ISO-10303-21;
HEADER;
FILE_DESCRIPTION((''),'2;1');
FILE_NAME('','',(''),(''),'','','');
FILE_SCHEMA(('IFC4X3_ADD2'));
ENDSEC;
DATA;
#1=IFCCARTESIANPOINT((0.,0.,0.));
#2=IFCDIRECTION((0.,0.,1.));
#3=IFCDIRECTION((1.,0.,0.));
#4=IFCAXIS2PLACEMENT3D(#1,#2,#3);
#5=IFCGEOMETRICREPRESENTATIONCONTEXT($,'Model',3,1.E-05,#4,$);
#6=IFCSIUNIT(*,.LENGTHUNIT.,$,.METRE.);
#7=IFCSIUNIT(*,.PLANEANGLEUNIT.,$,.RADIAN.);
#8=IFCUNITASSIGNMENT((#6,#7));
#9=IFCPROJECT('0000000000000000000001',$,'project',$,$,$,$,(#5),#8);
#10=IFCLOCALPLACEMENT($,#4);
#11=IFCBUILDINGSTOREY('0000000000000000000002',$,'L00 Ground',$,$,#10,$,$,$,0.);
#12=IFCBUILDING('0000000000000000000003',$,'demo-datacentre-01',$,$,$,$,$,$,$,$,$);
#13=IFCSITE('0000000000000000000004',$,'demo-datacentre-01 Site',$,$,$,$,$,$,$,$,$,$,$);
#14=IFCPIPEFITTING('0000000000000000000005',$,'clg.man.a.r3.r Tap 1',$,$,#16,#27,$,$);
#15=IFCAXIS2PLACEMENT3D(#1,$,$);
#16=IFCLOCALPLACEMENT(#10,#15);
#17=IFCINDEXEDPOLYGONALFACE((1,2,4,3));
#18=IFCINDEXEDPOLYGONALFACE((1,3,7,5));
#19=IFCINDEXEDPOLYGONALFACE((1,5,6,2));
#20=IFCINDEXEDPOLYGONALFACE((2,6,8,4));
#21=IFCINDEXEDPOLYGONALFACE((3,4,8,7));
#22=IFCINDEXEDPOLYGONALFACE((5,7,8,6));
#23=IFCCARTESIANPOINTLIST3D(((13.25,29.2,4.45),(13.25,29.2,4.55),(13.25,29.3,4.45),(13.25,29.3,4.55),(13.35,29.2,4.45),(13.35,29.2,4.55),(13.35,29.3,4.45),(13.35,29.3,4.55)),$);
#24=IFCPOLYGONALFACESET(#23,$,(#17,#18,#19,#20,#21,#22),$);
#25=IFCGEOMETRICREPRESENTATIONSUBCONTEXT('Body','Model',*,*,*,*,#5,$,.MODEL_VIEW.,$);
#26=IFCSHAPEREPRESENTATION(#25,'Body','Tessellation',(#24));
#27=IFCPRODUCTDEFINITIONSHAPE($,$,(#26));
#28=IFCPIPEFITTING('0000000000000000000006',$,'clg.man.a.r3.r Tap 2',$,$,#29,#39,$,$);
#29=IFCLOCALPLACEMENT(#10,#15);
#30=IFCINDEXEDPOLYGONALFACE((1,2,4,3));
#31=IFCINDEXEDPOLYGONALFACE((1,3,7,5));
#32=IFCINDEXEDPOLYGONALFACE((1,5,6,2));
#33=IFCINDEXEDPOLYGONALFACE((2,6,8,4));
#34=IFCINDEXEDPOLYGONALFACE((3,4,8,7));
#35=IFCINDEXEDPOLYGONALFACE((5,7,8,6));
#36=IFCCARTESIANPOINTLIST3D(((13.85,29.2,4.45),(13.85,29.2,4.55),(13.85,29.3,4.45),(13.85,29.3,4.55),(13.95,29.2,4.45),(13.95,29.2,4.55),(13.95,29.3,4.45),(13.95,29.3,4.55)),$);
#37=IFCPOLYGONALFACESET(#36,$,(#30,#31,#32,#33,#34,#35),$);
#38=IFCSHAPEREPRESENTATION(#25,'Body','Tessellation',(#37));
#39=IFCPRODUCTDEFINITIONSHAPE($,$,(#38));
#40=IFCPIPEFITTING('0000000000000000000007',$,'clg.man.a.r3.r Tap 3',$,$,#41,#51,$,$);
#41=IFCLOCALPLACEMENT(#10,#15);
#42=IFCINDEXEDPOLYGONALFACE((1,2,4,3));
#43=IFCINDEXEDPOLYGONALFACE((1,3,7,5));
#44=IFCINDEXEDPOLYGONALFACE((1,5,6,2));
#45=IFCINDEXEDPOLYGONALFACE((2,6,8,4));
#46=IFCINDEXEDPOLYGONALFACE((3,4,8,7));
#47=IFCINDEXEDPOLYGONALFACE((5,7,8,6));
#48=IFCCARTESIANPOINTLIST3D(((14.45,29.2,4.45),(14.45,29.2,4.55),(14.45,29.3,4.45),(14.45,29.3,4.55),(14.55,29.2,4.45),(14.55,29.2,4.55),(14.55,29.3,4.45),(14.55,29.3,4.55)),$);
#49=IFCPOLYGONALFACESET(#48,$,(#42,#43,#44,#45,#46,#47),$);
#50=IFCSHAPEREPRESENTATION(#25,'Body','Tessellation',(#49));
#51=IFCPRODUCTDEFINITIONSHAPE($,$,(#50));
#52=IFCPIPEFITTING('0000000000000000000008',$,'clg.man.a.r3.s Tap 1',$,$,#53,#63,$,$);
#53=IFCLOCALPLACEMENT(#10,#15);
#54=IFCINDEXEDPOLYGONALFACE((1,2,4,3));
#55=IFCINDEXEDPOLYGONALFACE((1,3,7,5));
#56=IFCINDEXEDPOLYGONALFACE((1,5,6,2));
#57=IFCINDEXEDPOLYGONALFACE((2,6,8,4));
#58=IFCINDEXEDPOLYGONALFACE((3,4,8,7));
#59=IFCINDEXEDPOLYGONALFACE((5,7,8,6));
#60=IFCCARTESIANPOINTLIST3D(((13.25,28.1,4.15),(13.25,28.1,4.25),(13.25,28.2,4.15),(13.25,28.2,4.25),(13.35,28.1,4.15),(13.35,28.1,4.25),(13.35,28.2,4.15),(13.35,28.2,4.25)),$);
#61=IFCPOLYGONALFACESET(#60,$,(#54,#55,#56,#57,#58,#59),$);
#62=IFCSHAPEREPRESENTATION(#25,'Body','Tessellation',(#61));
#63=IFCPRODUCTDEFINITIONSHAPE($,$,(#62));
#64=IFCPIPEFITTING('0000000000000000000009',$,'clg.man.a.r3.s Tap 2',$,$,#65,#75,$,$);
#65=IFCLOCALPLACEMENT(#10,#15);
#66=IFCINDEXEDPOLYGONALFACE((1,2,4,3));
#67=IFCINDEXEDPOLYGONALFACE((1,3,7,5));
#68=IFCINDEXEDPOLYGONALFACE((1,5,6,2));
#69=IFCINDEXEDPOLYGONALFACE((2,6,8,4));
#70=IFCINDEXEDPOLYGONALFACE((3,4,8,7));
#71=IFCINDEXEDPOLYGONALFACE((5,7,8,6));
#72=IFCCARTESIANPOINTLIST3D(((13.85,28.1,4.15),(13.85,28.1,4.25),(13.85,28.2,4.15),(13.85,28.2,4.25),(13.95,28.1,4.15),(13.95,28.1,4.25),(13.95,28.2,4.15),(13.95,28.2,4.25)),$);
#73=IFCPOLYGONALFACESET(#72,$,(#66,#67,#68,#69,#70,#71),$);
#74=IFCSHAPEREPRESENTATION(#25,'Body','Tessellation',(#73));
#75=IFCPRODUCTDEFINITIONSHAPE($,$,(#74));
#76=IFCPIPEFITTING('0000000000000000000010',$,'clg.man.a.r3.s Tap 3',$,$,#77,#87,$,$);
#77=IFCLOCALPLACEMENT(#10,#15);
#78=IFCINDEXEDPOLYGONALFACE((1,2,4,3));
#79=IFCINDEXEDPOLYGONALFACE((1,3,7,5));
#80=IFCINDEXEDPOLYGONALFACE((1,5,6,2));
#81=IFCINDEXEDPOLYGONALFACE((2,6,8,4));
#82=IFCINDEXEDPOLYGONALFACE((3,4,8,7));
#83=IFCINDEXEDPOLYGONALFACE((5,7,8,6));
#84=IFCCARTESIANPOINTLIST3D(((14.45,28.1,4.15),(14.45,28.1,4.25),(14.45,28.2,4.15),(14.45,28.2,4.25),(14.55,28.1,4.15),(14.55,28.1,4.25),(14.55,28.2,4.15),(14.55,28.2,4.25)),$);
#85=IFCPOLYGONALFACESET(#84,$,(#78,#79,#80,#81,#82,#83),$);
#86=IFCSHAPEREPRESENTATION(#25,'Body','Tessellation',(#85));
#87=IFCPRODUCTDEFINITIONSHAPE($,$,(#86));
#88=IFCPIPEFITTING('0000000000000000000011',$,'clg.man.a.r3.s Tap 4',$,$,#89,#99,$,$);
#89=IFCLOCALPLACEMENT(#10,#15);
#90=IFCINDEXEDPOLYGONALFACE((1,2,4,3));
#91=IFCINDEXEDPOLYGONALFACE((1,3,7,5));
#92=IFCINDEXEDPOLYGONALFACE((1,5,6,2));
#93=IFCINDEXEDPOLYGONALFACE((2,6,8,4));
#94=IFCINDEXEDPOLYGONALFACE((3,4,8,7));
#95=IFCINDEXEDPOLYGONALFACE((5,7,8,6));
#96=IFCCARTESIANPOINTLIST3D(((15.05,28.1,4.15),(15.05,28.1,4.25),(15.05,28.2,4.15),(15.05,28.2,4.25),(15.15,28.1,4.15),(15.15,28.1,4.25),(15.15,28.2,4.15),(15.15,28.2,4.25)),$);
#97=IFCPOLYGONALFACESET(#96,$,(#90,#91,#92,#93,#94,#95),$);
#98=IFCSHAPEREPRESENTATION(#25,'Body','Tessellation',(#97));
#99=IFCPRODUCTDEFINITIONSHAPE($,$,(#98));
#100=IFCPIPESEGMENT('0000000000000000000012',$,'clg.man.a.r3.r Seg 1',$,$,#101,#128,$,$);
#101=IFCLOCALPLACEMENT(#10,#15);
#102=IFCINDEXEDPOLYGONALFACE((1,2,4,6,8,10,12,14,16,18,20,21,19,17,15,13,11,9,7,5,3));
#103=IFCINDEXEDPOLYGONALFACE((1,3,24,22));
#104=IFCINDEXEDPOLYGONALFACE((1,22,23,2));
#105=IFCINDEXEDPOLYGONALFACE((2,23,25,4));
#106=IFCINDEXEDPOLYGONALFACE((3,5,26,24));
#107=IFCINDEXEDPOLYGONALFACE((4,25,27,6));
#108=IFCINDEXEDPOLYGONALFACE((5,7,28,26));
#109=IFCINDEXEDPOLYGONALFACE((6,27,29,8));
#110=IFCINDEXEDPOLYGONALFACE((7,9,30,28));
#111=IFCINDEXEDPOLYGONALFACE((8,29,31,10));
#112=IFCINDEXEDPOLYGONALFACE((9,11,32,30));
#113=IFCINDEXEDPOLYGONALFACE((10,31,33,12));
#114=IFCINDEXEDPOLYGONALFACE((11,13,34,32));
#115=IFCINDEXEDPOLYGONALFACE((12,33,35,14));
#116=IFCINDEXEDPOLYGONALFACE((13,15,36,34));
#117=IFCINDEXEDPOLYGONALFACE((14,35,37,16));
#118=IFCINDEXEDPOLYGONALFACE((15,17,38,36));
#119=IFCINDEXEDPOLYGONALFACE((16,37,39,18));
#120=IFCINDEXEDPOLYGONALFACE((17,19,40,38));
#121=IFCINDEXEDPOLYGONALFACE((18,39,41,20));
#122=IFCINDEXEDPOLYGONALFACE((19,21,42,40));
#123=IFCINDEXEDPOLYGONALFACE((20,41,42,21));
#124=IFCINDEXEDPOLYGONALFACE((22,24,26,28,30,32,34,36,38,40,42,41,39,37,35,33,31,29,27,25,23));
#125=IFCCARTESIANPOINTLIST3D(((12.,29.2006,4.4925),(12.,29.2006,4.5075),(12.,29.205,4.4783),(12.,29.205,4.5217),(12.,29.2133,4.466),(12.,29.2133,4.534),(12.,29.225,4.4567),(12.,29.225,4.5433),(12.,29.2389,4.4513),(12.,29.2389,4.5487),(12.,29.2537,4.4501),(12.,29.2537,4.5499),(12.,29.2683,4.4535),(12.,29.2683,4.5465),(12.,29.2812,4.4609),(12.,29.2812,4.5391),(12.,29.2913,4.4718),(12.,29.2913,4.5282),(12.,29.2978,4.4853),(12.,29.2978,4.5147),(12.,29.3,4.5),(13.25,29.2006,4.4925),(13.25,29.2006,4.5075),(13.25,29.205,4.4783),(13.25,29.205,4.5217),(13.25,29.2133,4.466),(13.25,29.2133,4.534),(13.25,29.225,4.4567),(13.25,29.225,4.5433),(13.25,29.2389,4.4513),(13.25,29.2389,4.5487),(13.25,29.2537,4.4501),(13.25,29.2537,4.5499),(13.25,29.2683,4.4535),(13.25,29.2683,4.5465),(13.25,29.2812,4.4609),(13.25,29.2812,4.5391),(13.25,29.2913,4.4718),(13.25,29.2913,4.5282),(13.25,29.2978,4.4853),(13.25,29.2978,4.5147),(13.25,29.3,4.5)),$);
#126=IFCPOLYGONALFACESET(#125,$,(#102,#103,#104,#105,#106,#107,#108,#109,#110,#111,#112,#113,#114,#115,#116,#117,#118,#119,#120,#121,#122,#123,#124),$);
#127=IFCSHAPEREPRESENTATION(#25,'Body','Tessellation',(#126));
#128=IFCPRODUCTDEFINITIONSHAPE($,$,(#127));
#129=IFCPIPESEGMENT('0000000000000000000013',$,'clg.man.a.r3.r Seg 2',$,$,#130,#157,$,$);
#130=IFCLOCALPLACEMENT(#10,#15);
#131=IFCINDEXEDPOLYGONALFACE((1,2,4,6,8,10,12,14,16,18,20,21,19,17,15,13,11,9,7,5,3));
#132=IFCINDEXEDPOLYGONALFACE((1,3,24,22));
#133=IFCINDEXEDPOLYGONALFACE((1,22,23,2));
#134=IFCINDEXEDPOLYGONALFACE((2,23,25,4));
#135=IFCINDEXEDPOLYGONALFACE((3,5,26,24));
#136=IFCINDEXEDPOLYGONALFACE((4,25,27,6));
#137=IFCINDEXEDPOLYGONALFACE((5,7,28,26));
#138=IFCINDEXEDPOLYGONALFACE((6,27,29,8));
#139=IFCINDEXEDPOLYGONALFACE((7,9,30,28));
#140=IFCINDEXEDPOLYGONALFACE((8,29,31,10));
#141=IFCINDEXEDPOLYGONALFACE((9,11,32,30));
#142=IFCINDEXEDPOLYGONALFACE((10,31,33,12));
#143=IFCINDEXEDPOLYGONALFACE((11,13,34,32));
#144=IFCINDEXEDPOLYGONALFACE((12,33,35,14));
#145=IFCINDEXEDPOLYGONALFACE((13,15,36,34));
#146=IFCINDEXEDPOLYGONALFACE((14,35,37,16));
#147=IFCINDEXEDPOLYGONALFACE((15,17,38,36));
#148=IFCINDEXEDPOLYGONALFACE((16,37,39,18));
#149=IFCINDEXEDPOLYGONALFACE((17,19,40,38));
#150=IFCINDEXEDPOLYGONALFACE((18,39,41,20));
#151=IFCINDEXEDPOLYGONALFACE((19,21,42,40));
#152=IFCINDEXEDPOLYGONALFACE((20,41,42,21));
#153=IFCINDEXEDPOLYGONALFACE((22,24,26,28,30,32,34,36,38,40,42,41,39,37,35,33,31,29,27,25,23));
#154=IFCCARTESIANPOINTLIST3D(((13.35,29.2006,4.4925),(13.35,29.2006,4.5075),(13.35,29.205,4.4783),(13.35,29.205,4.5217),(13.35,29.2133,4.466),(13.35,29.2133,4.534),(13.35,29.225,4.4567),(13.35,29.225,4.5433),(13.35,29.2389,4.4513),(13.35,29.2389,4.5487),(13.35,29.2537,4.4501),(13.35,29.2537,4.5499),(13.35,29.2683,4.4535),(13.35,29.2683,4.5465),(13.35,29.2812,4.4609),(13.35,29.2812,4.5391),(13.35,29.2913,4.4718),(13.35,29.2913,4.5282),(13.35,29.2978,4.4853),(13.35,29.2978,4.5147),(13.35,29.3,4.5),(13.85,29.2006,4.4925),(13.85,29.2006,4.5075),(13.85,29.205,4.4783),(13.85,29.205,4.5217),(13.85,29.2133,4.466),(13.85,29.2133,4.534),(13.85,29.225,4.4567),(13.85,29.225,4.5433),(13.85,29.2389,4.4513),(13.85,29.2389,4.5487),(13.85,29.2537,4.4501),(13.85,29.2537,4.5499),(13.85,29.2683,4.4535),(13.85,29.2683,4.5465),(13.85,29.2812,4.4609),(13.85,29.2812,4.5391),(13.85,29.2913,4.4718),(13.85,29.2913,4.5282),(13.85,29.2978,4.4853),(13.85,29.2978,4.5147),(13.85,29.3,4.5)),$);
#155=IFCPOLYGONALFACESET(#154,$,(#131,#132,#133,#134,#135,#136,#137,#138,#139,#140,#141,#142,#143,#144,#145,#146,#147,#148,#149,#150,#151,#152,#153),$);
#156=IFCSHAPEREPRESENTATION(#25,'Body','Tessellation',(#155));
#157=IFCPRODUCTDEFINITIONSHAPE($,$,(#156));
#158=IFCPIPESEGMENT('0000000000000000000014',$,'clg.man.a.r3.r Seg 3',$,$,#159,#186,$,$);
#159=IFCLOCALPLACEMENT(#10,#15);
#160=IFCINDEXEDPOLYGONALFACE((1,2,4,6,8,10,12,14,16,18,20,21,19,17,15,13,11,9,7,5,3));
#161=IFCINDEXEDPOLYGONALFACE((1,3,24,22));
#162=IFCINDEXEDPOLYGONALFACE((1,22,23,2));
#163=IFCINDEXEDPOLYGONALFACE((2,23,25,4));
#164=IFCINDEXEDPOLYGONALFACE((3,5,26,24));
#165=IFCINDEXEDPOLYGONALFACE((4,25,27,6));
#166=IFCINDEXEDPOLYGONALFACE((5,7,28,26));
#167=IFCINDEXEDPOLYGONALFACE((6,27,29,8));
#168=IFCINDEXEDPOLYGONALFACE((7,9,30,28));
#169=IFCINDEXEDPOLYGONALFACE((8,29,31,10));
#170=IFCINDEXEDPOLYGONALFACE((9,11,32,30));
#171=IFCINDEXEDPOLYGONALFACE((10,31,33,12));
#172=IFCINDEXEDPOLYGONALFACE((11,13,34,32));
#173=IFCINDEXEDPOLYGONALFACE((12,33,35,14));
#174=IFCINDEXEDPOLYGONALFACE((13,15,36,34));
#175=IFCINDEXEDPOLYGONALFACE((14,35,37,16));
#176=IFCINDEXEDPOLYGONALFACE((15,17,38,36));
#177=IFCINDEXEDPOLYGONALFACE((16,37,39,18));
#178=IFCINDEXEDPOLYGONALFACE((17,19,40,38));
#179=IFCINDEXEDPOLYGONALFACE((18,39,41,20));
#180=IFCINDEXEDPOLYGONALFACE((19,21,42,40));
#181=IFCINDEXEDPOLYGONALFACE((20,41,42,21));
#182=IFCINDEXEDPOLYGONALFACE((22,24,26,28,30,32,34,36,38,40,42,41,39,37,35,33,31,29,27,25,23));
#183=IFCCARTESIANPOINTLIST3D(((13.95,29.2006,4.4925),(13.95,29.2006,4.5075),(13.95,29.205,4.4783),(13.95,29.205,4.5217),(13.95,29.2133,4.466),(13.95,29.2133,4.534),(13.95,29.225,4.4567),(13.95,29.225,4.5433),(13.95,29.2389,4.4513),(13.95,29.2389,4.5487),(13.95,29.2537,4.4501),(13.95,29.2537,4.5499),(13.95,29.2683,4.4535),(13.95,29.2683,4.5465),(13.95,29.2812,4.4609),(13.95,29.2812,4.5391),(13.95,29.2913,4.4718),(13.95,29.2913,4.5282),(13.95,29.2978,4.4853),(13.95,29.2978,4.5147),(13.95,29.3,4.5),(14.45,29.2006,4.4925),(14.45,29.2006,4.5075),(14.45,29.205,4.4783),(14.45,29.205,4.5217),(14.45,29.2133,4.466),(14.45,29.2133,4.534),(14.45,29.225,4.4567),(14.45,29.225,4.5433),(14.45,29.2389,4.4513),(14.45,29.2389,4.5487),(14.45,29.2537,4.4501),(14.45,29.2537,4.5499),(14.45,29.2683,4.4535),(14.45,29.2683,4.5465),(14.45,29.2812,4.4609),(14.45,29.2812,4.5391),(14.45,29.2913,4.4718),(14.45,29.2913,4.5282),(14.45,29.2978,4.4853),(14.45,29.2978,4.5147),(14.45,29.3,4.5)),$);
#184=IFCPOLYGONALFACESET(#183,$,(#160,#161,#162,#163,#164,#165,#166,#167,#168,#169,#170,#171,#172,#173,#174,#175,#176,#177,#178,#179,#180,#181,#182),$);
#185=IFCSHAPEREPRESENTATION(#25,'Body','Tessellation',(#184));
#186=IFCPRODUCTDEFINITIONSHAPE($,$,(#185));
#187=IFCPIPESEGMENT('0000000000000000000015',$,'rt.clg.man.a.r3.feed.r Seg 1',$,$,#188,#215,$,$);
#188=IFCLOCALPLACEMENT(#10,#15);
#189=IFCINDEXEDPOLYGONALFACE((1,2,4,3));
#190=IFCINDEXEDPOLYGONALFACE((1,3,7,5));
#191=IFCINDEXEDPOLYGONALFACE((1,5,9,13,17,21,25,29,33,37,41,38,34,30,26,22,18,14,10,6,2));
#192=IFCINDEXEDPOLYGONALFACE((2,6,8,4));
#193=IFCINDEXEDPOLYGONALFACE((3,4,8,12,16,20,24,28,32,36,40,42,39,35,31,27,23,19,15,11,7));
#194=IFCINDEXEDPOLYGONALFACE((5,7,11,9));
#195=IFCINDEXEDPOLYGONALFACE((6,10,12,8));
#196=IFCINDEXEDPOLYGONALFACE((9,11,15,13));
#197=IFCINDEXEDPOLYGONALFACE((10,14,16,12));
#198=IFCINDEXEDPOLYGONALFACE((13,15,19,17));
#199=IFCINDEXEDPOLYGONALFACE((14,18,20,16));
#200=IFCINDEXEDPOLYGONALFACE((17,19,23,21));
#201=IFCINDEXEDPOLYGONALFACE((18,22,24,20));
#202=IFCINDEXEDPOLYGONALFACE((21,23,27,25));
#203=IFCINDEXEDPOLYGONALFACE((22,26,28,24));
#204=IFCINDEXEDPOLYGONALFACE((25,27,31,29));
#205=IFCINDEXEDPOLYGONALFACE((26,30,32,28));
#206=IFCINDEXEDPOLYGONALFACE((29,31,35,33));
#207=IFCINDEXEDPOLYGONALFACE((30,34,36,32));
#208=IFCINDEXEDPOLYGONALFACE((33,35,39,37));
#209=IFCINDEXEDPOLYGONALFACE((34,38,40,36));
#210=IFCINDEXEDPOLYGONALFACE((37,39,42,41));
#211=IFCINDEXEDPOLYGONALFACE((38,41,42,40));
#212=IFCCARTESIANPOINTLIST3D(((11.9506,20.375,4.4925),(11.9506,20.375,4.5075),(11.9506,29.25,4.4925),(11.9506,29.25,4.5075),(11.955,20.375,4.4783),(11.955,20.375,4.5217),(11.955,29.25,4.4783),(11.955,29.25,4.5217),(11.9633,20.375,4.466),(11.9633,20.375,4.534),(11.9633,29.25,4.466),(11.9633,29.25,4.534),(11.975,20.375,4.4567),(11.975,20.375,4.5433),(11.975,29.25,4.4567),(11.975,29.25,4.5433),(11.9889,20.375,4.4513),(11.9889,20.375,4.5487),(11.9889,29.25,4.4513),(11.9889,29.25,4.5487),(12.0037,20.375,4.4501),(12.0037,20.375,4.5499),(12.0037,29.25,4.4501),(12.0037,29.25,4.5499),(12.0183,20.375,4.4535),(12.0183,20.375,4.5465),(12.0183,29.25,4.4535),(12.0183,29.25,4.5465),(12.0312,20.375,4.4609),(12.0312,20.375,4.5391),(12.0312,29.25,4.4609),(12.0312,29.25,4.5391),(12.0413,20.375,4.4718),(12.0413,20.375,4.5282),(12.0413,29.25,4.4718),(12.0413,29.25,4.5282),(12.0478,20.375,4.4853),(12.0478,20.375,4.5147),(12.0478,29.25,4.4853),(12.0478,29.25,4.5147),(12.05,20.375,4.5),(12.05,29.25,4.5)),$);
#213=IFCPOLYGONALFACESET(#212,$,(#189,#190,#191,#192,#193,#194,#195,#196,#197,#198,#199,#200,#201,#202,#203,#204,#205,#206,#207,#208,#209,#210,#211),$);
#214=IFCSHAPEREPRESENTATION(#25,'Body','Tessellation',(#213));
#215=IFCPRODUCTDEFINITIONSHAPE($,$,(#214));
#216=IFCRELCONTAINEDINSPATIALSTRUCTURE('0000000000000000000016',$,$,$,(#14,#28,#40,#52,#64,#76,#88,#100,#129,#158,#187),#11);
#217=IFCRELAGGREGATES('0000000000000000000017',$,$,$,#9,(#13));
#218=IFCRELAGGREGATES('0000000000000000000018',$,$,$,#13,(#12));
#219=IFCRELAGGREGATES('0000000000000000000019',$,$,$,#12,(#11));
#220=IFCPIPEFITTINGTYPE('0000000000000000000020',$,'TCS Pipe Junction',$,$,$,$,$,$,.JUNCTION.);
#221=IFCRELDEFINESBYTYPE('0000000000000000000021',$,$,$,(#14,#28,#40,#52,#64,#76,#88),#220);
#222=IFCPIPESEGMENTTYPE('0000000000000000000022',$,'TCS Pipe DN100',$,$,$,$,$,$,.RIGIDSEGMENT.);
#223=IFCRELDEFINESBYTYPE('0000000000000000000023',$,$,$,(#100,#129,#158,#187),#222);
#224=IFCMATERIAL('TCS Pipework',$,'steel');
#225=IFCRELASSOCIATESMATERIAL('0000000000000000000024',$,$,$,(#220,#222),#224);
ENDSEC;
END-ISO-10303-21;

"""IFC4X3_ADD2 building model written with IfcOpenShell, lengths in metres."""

from ifc_helpers import new_model, si_unit, frame, origin_with_axes, place, context, subcontext, project, spatial, rectangle, circle, extrude, material, type_object, element, save


model = new_model("IFC4X3_ADD2")

# Units and contexts
model_context = context("Model", 3, precision=1e-05, world=origin_with_axes())
body_context = subcontext(model_context, "Body", "Model", "MODEL_VIEW")
ifc_project = project(units=[si_unit("LENGTHUNIT", "METRE"), si_unit("PLANEANGLEUNIT", "RADIAN")], contexts=[model_context])

# Site, building, storey
site = spatial("IfcSite", under=ifc_project, Name="demo-datacentre-01 Site")
building = spatial("IfcBuilding", under=site, Name="demo-datacentre-01")
storey_placement = place(None, origin_with_axes())
storey = spatial("IfcBuildingStorey", under=building, at=storey_placement, Name="L00 Ground", Elevation=0.0)

# Pipe fittings
ifc_material = material(Name="TCS Pipework", Category="steel")
pipe_fitting_type = type_object("IfcPipeFittingType", Name="TCS Pipe Junction", PredefinedType="JUNCTION", material=ifc_material)
for number, where, z_axis, x_axis, name in (
    (1, (13.3, 29.25, 4.45), (0.0, 0.0, 1.0), (1.0, 0.0, 0.0), "clg.man.a.r3.r Tap 1"),
    (2, (13.9, 29.25, 4.45), (0.0, 0.0, 1.0), (1.0, 0.0, 0.0), "clg.man.a.r3.r Tap 2"),
    (3, (14.5, 29.25, 4.45), (0.0, 0.0, 1.0), (1.0, 0.0, 0.0), "clg.man.a.r3.r Tap 3"),
    (4, (13.3, 28.15, 4.15), (0.0, 0.0, 1.0), (1.0, 0.0, 0.0), "clg.man.a.r3.s Tap 1"),
    (5, (13.9, 28.15, 4.15), (0.0, 0.0, 1.0), (1.0, 0.0, 0.0), "clg.man.a.r3.s Tap 2"),
    (6, (14.5, 28.15, 4.15), (0.0, 0.0, 1.0), (1.0, 0.0, 0.0), "clg.man.a.r3.s Tap 3"),
    (7, (15.1, 28.15, 4.15), (0.0, 0.0, 1.0), (1.0, 0.0, 0.0), "clg.man.a.r3.s Tap 4"),
):
    element("IfcPipeFitting", number, at=place(storey_placement, frame(where, z_axis=z_axis, x_axis=x_axis)), inside=storey, type_object=pipe_fitting_type, Name=name, context=body_context, shape_type="SweptSolid", body=[
        extrude(rectangle(XDim=0.1, YDim=0.1), origin_with_axes(), (0.0, 0.0, 1.0), 0.1),
    ])

# Pipe segments
pipe_segment_type_1 = type_object("IfcPipeSegmentType", Name="TCS Pipe DN100", PredefinedType="RIGIDSEGMENT", material=ifc_material)
pipe_segment_1_placement = place(storey_placement, frame((12.0, 29.25, 4.5), z_axis=(1.0, 0.0, 0.0), x_axis=(0.0, 1.0, 0.0)))
element("IfcPipeSegment", 8, at=pipe_segment_1_placement, inside=storey, type_object=pipe_segment_type_1, Name="clg.man.a.r3.r Seg 1", context=body_context, shape_type="SweptSolid", body=[
    extrude(circle(Radius=0.05), origin_with_axes(), (0.0, 0.0, 1.0), 1.25),
])
for number, where, z_axis, x_axis, name in (
    (9, (13.35, 29.25, 4.5), (1.0, 0.0, 0.0), (0.0, 1.0, 0.0), "clg.man.a.r3.r Seg 2"),
    (10, (13.95, 29.25, 4.5), (1.0, 0.0, 0.0), (0.0, 1.0, 0.0), "clg.man.a.r3.r Seg 3"),
):
    element("IfcPipeSegment", number, at=place(storey_placement, frame(where, z_axis=z_axis, x_axis=x_axis)), inside=storey, type_object=pipe_segment_type_1, Name=name, context=body_context, shape_type="SweptSolid", body=[
        extrude(circle(Radius=0.05), origin_with_axes(), (0.0, 0.0, 1.0), 0.5),
    ])
pipe_segment_2_placement = place(storey_placement, frame((12.0, 29.25, 4.5), z_axis=(0.0, -1.0, 0.0), x_axis=(1.0, 0.0, 0.0)))
element("IfcPipeSegment", 11, at=pipe_segment_2_placement, inside=storey, type_object=pipe_segment_type_1, Name="rt.clg.man.a.r3.feed.r Seg 1", context=body_context, shape_type="SweptSolid", body=[
    extrude(circle(Radius=0.05), origin_with_axes(), (0.0, 0.0, 1.0), 8.875),
])

save(model, "model.ifc")
